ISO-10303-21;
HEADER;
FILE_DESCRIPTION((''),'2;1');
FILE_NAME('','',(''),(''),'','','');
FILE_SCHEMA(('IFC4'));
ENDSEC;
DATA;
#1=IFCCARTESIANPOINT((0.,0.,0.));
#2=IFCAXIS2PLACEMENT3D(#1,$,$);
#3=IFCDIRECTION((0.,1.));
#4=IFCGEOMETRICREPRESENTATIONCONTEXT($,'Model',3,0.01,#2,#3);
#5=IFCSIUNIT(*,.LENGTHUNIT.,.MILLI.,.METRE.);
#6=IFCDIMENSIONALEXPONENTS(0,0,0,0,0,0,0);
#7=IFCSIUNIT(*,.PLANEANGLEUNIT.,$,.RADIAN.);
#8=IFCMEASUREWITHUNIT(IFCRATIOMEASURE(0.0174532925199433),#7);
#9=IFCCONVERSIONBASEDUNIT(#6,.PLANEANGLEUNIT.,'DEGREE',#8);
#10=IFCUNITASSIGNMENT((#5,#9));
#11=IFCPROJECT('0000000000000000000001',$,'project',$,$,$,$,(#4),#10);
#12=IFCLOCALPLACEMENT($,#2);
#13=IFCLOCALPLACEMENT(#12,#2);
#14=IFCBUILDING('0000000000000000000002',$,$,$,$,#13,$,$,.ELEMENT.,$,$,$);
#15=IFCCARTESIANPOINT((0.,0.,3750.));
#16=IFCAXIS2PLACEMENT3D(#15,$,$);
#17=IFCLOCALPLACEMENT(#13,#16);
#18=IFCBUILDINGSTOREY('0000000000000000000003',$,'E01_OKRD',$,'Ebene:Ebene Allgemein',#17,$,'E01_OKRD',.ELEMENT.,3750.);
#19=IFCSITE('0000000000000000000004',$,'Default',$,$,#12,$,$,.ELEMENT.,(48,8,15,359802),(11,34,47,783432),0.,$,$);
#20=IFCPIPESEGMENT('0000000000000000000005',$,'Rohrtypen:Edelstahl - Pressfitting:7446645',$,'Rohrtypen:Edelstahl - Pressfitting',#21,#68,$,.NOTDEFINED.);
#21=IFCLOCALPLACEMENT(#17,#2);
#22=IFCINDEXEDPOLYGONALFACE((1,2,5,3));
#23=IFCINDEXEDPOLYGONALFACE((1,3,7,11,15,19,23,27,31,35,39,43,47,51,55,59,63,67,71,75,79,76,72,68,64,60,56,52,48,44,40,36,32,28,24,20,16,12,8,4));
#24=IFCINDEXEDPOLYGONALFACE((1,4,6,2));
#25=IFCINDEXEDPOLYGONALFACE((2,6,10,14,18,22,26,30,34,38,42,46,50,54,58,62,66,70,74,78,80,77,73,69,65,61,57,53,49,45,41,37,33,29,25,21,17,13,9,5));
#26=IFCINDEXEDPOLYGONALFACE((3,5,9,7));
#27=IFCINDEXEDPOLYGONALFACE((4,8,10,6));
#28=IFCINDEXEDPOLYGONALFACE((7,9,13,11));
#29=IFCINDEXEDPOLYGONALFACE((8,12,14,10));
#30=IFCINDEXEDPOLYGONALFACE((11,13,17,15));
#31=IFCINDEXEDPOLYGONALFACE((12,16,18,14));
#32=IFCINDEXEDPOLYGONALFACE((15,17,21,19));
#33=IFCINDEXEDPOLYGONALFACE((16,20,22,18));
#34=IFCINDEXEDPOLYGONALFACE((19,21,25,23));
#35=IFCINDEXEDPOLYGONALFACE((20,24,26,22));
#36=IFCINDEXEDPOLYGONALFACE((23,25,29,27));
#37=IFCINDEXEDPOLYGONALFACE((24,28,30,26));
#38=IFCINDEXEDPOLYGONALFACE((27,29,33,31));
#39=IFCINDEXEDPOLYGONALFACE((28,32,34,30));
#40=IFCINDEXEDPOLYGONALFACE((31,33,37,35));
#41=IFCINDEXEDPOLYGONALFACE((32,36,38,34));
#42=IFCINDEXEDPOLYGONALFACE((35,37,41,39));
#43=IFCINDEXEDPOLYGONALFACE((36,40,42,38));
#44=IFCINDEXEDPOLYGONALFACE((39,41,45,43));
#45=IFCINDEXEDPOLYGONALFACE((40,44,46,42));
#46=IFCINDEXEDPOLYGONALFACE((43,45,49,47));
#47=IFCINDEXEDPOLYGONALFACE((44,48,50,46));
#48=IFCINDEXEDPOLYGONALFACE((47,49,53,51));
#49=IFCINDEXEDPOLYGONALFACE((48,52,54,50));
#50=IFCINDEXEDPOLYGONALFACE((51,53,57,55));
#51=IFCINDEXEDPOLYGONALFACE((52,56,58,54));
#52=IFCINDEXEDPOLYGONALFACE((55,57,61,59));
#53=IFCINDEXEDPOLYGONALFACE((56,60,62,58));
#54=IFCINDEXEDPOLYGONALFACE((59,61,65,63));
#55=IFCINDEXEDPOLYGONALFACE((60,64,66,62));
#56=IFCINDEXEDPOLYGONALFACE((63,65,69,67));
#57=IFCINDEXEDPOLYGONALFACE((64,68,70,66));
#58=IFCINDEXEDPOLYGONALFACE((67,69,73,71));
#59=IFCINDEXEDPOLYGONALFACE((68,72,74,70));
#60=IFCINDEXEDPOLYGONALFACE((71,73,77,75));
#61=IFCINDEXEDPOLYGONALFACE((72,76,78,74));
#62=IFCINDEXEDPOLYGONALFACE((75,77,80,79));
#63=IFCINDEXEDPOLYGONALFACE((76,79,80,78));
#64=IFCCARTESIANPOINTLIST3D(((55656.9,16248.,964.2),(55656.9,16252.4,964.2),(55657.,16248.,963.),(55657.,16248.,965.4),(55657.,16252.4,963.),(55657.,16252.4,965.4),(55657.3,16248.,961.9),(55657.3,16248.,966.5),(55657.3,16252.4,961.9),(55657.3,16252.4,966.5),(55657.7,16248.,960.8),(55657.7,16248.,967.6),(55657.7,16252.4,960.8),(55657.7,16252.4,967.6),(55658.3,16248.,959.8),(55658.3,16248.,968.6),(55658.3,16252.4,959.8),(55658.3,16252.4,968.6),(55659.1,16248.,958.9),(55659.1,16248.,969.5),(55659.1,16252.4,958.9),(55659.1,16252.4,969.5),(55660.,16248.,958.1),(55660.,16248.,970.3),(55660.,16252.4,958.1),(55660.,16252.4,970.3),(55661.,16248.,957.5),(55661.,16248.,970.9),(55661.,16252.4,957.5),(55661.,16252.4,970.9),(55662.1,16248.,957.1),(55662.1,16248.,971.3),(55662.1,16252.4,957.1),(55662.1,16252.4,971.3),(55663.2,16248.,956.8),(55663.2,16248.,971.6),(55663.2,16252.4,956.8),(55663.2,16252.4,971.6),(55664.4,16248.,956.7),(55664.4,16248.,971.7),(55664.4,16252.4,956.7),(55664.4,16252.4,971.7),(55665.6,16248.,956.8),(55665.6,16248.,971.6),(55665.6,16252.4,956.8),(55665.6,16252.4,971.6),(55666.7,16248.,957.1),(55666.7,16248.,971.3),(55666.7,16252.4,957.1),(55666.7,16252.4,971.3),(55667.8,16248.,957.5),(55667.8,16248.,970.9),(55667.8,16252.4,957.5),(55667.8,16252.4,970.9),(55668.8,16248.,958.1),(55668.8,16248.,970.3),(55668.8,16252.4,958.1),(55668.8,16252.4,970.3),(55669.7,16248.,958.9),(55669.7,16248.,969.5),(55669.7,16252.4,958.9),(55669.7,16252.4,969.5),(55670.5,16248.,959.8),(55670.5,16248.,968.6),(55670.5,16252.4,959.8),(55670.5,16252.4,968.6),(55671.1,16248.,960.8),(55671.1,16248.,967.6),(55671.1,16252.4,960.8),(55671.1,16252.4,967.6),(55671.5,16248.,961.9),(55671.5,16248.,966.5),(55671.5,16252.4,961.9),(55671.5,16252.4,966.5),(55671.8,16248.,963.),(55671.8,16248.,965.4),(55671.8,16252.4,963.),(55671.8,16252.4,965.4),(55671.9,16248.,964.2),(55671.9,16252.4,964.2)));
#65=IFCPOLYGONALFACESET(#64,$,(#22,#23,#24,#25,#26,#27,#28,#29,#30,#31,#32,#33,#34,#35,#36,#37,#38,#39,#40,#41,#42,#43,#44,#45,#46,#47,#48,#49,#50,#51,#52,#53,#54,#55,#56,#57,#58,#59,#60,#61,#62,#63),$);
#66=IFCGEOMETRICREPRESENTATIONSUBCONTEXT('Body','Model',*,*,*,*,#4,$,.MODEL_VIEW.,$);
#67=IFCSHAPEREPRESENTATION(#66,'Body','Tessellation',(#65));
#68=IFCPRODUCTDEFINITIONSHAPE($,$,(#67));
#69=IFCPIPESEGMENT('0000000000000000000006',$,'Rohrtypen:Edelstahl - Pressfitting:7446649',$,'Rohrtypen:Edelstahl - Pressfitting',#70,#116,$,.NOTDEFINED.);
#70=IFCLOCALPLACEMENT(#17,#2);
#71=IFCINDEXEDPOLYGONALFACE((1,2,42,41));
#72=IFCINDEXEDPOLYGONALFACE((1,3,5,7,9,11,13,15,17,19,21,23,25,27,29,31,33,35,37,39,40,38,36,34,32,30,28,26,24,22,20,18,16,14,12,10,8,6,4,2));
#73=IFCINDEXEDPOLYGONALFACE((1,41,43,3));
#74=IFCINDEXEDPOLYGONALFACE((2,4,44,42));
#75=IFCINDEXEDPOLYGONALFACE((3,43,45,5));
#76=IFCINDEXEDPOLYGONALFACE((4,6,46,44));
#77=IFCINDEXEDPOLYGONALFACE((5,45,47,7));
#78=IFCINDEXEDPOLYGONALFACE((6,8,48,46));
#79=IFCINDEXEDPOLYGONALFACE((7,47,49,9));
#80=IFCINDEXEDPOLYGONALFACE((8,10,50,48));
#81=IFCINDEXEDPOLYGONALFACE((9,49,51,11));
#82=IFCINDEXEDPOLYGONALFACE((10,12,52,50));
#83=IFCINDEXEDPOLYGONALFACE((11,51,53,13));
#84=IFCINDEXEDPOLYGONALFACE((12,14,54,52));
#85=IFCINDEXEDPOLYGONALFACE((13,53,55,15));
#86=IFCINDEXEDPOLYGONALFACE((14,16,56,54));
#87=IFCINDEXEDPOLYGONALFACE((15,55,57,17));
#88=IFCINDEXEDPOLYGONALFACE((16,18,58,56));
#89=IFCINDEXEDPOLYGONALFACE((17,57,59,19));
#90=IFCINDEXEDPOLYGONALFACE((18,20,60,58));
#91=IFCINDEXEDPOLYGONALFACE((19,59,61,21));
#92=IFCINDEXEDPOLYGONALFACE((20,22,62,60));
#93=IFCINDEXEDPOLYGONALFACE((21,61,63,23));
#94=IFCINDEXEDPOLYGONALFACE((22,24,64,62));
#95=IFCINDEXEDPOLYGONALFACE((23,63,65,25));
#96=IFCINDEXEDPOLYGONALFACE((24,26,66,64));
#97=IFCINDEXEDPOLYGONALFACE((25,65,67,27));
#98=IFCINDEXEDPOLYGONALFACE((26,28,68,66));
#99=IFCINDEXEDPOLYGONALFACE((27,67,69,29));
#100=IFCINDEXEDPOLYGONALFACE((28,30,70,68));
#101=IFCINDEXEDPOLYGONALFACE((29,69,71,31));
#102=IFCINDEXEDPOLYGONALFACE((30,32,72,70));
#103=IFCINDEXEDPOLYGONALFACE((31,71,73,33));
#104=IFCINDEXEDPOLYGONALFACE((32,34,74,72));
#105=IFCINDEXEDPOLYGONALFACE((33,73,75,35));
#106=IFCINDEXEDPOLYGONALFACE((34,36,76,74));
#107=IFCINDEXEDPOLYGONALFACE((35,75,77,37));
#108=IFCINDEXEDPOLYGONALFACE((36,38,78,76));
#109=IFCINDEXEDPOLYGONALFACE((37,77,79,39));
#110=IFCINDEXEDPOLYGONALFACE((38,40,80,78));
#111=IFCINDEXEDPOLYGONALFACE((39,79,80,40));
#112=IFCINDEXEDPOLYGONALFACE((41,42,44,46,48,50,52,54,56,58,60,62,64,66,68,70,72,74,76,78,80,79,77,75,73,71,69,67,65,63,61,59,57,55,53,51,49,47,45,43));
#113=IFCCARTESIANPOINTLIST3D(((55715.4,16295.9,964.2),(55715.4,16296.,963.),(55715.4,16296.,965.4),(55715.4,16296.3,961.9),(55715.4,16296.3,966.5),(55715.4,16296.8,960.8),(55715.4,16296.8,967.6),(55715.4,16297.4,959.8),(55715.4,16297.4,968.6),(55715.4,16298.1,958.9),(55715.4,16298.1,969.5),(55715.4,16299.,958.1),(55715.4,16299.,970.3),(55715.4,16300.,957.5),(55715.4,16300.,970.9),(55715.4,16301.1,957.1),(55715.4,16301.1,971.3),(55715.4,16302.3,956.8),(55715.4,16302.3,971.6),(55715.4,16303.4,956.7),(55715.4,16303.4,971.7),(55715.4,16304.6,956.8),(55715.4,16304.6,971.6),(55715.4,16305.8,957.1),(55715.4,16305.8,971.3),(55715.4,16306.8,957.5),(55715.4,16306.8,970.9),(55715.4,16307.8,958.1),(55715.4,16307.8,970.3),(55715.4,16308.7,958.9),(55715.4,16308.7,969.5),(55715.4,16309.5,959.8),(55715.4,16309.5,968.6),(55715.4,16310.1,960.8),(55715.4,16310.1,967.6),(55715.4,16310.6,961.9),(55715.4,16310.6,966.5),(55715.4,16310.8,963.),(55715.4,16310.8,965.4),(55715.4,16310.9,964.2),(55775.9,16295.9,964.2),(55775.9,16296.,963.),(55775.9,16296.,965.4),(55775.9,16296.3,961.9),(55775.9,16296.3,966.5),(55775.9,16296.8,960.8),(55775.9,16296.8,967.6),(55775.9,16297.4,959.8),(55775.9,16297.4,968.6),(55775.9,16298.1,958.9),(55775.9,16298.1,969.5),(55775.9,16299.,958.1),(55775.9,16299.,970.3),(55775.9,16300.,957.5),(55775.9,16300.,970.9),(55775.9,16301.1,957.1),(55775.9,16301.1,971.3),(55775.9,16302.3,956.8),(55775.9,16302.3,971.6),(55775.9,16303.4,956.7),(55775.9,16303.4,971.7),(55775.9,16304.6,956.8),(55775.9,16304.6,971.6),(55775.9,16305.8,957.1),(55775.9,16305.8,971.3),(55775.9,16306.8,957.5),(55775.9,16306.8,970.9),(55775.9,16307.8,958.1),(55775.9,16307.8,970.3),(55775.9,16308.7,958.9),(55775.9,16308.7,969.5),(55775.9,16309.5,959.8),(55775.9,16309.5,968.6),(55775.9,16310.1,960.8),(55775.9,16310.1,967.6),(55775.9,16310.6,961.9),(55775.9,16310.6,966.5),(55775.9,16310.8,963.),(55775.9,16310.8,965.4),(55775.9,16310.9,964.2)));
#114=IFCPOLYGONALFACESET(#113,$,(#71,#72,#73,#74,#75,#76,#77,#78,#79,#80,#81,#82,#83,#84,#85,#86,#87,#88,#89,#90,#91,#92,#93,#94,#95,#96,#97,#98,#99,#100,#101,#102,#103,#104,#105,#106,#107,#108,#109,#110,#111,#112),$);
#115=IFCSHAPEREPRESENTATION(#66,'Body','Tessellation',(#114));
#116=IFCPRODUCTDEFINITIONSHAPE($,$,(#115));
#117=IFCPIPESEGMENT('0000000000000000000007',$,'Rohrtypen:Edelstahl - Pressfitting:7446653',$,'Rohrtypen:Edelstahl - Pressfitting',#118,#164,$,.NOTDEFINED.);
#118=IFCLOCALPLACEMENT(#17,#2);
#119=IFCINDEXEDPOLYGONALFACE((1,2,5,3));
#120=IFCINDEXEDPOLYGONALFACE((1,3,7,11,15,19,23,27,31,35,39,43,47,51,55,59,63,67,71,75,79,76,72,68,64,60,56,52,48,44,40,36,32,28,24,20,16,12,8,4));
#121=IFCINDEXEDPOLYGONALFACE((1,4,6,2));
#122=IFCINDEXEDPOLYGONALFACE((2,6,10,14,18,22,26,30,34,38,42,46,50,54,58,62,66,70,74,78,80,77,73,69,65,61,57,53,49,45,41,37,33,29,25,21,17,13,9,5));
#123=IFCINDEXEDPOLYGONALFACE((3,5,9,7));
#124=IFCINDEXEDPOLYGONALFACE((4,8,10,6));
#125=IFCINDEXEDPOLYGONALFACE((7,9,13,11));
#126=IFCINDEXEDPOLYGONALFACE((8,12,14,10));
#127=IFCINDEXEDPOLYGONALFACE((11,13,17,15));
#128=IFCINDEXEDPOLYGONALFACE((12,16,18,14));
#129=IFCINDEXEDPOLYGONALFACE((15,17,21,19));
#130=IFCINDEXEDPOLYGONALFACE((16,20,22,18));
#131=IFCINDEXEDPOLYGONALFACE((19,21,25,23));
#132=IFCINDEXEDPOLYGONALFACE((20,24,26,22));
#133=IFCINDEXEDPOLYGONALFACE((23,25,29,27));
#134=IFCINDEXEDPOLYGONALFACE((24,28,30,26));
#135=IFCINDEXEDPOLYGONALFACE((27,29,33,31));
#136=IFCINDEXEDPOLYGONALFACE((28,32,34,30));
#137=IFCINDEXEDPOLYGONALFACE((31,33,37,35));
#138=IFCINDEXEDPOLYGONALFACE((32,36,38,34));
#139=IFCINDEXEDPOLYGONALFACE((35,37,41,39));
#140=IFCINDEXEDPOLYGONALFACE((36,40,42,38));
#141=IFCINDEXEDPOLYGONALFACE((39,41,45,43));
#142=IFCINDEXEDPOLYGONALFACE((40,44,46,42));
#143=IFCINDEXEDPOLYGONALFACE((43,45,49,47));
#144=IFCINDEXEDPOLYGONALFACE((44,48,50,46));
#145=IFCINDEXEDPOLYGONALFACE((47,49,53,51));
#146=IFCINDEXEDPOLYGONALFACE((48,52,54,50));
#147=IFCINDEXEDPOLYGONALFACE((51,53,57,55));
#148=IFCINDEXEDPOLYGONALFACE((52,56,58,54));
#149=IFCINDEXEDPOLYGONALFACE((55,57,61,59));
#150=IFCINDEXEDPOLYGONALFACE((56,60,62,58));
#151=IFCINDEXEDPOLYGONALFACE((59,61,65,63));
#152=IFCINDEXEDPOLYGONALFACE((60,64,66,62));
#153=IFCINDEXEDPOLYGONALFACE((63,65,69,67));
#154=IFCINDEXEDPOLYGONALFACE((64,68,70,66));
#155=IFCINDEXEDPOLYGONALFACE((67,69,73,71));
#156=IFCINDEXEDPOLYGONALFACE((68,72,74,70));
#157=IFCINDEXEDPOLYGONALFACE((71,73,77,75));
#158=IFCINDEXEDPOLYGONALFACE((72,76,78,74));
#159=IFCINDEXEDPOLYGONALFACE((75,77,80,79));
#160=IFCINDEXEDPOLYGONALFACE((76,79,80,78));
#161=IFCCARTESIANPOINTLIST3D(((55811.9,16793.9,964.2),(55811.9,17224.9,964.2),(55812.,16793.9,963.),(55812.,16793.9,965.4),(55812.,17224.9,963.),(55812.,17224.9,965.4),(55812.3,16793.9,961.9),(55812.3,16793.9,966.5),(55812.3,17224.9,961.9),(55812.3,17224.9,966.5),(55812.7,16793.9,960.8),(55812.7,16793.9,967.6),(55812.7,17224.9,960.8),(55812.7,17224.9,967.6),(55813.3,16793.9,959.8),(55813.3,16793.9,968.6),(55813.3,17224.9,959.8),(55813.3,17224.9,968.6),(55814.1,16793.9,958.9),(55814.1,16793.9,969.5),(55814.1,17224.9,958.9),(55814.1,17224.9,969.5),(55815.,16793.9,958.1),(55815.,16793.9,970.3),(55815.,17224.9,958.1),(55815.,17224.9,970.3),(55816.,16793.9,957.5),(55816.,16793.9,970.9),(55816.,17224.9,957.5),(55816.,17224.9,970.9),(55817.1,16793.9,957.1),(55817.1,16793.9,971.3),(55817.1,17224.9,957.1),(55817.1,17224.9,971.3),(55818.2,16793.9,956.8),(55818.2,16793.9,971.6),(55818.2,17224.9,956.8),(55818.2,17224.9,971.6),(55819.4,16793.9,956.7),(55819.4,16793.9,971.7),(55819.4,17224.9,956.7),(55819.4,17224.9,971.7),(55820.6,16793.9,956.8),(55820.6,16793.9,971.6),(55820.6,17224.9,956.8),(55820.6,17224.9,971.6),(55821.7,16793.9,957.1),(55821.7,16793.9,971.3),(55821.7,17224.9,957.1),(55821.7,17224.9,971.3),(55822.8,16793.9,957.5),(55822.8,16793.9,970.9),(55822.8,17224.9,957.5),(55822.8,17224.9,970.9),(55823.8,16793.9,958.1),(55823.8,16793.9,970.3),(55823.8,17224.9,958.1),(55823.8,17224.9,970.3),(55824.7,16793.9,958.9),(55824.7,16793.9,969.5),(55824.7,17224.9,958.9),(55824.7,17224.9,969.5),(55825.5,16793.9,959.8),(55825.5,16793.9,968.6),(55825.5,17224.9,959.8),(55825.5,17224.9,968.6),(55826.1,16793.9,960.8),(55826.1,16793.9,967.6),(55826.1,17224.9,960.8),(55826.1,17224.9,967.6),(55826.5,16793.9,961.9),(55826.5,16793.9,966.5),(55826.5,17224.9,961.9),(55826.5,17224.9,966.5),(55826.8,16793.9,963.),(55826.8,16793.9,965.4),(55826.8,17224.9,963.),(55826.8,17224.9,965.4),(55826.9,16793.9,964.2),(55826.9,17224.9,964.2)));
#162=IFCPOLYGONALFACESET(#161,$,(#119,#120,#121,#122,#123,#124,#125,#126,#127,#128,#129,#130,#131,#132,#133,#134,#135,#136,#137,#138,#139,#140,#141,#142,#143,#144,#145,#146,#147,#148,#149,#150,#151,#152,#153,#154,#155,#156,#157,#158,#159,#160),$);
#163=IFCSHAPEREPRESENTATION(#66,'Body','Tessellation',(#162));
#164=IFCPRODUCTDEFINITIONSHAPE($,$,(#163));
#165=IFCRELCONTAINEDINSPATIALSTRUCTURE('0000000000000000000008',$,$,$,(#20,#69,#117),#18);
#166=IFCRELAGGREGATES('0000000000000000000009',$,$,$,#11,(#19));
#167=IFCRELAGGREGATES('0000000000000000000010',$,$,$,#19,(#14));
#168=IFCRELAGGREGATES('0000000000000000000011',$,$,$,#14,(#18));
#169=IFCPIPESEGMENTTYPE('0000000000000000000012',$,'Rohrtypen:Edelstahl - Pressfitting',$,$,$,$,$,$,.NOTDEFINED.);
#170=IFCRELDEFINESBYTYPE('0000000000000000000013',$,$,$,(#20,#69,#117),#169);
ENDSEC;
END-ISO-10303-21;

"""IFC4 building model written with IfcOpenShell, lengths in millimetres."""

from ifc_helpers import new_model, entity, si_unit, converted_unit, direction, frame, origin, place, context, subcontext, project, spatial, indexed_curve, outline, extrude, type_object, element, save


model = new_model("IFC4")

# Units and contexts
model_context = context("Model", 3, precision=0.01, world=origin(), true_north=direction((0.0, 1.0)))
body_context = subcontext(model_context, "Body", "Model", "MODEL_VIEW")
ifc_project = project(units=[si_unit("LENGTHUNIT", "METRE", prefix="MILLI"), converted_unit("PLANEANGLEUNIT", "DEGREE", entity("IfcRatioMeasure", 0.0174532925199433), si_unit("PLANEANGLEUNIT", "RADIAN"), dimensions=[0, 0, 0, 0, 0, 0, 0])], contexts=[model_context])

# Site, building, storey
site_placement = place(None, origin())
site = spatial("IfcSite", under=ifc_project, at=site_placement, Name="Default", CompositionType="ELEMENT", RefLatitude=(48, 8, 15, 359802), RefLongitude=(11, 34, 47, 783432), RefElevation=0.0)
building_placement = place(site_placement, origin())
building = spatial("IfcBuilding", under=site, at=building_placement, CompositionType="ELEMENT")
storey_placement = place(building_placement, frame((0.0, 0.0, 3750.0)))
storey = spatial("IfcBuildingStorey", under=building, at=storey_placement, Name="E01_OKRD", ObjectType="Ebene:Ebene Allgemein", LongName="E01_OKRD", CompositionType="ELEMENT", Elevation=3750.0)

# Pipe segments
pipe_segment_type_1 = type_object("IfcPipeSegmentType", Name="Rohrtypen:Edelstahl - Pressfitting", PredefinedType="NOTDEFINED")
pipe_segment_1_placement = place(storey_placement, origin())
element("IfcPipeSegment", 1, at=pipe_segment_1_placement, inside=storey, type_object=pipe_segment_type_1, Name="Rohrtypen:Edelstahl - Pressfitting:7446645", ObjectType="Rohrtypen:Edelstahl - Pressfitting", PredefinedType="NOTDEFINED", context=body_context, shape_type="SweptSolid", body=[
    extrude(outline(indexed_curve([(7.5, 0.0), (7.4, 1.2), (7.1, 2.3), (6.7, 3.4), (6.1, 4.4), (5.3, 5.3), (4.4, 6.1), (3.4, 6.7), (2.3, 7.1), (1.2, 7.4), (0.0, 7.5), (-1.2, 7.4), (-2.3, 7.1), (-3.4, 6.7), (-4.4, 6.1), (-5.3, 5.3), (-6.1, 4.4), (-6.7, 3.4), (-7.1, 2.3), (-7.4, 1.2), (-7.5, 0.0), (-7.4, -1.2), (-7.1, -2.3), (-6.7, -3.4), (-6.1, -4.4), (-5.3, -5.3), (-4.4, -6.1), (-3.4, -6.7), (-2.3, -7.1), (-1.2, -7.4), (0.0, -7.5), (1.2, -7.4), (2.3, -7.1), (3.4, -6.7), (4.4, -6.1), (5.3, -5.3), (6.1, -4.4), (6.7, -3.4), (7.1, -2.3), (7.4, -1.2), (7.5, 0.0)], self_intersect=False)), frame((55664.4, 16248.0, 964.2), z_axis=(0.0, 1.0, 0.0), x_axis=(1.0, 0.0, 0.0)), (0.0, 0.0, 1.0), 4.4),
])
pipe_segment_2_placement = place(storey_placement, origin())
element("IfcPipeSegment", 2, at=pipe_segment_2_placement, inside=storey, type_object=pipe_segment_type_1, Name="Rohrtypen:Edelstahl - Pressfitting:7446649", ObjectType="Rohrtypen:Edelstahl - Pressfitting", PredefinedType="NOTDEFINED", context=body_context, shape_type="SweptSolid", body=[
    extrude(outline(indexed_curve([(7.5, 0.0), (7.4, 1.2), (7.1, 2.3), (6.7, 3.4), (6.1, 4.4), (5.3, 5.3), (4.4, 6.1), (3.4, 6.7), (2.3, 7.1), (1.2, 7.4), (0.0, 7.5), (-1.2, 7.4), (-2.3, 7.1), (-3.4, 6.7), (-4.4, 6.1), (-5.3, 5.3), (-6.1, 4.4), (-6.7, 3.4), (-7.1, 2.3), (-7.4, 1.2), (-7.5, 0.0), (-7.4, -1.2), (-7.1, -2.3), (-6.7, -3.4), (-6.1, -4.4), (-5.3, -5.3), (-4.4, -6.1), (-3.4, -6.7), (-2.3, -7.1), (-1.2, -7.4), (0.0, -7.5), (1.2, -7.4), (2.3, -7.1), (3.4, -6.7), (4.4, -6.1), (5.3, -5.3), (6.1, -4.4), (6.7, -3.4), (7.1, -2.3), (7.4, -1.2), (7.5, 0.0)], self_intersect=False)), frame((55775.9, 16303.4, 964.2), z_axis=(-1.0, 0.0, 0.000221), x_axis=(0.0, -1.0, 0.0)), (0.0, 0.0, 1.0), 60.5),
])
pipe_segment_3_placement = place(storey_placement, origin())
element("IfcPipeSegment", 3, at=pipe_segment_3_placement, inside=storey, type_object=pipe_segment_type_1, Name="Rohrtypen:Edelstahl - Pressfitting:7446653", ObjectType="Rohrtypen:Edelstahl - Pressfitting", PredefinedType="NOTDEFINED", context=body_context, shape_type="SweptSolid", body=[
    extrude(outline(indexed_curve([(7.5, 0.0), (7.4, 1.2), (7.1, 2.3), (6.7, 3.4), (6.1, 4.4), (5.3, 5.3), (4.4, 6.1), (3.4, 6.7), (2.3, 7.1), (1.2, 7.4), (0.0, 7.5), (-1.2, 7.4), (-2.3, 7.1), (-3.4, 6.7), (-4.4, 6.1), (-5.3, 5.3), (-6.1, 4.4), (-6.7, 3.4), (-7.1, 2.3), (-7.4, 1.2), (-7.5, 0.0), (-7.4, -1.2), (-7.1, -2.3), (-6.7, -3.4), (-6.1, -4.4), (-5.3, -5.3), (-4.4, -6.1), (-3.4, -6.7), (-2.3, -7.1), (-1.2, -7.4), (0.0, -7.5), (1.2, -7.4), (2.3, -7.1), (3.4, -6.7), (4.4, -6.1), (5.3, -5.3), (6.1, -4.4), (6.7, -3.4), (7.1, -2.3), (7.4, -1.2), (7.5, 0.0)], self_intersect=False)), frame((55819.4, 16793.9, 964.2), z_axis=(0.0, 1.0, 0.0), x_axis=(1.0, 0.0, 0.0)), (0.0, 0.0, 1.0), 431.1),
])

save(model, "model.ifc")
